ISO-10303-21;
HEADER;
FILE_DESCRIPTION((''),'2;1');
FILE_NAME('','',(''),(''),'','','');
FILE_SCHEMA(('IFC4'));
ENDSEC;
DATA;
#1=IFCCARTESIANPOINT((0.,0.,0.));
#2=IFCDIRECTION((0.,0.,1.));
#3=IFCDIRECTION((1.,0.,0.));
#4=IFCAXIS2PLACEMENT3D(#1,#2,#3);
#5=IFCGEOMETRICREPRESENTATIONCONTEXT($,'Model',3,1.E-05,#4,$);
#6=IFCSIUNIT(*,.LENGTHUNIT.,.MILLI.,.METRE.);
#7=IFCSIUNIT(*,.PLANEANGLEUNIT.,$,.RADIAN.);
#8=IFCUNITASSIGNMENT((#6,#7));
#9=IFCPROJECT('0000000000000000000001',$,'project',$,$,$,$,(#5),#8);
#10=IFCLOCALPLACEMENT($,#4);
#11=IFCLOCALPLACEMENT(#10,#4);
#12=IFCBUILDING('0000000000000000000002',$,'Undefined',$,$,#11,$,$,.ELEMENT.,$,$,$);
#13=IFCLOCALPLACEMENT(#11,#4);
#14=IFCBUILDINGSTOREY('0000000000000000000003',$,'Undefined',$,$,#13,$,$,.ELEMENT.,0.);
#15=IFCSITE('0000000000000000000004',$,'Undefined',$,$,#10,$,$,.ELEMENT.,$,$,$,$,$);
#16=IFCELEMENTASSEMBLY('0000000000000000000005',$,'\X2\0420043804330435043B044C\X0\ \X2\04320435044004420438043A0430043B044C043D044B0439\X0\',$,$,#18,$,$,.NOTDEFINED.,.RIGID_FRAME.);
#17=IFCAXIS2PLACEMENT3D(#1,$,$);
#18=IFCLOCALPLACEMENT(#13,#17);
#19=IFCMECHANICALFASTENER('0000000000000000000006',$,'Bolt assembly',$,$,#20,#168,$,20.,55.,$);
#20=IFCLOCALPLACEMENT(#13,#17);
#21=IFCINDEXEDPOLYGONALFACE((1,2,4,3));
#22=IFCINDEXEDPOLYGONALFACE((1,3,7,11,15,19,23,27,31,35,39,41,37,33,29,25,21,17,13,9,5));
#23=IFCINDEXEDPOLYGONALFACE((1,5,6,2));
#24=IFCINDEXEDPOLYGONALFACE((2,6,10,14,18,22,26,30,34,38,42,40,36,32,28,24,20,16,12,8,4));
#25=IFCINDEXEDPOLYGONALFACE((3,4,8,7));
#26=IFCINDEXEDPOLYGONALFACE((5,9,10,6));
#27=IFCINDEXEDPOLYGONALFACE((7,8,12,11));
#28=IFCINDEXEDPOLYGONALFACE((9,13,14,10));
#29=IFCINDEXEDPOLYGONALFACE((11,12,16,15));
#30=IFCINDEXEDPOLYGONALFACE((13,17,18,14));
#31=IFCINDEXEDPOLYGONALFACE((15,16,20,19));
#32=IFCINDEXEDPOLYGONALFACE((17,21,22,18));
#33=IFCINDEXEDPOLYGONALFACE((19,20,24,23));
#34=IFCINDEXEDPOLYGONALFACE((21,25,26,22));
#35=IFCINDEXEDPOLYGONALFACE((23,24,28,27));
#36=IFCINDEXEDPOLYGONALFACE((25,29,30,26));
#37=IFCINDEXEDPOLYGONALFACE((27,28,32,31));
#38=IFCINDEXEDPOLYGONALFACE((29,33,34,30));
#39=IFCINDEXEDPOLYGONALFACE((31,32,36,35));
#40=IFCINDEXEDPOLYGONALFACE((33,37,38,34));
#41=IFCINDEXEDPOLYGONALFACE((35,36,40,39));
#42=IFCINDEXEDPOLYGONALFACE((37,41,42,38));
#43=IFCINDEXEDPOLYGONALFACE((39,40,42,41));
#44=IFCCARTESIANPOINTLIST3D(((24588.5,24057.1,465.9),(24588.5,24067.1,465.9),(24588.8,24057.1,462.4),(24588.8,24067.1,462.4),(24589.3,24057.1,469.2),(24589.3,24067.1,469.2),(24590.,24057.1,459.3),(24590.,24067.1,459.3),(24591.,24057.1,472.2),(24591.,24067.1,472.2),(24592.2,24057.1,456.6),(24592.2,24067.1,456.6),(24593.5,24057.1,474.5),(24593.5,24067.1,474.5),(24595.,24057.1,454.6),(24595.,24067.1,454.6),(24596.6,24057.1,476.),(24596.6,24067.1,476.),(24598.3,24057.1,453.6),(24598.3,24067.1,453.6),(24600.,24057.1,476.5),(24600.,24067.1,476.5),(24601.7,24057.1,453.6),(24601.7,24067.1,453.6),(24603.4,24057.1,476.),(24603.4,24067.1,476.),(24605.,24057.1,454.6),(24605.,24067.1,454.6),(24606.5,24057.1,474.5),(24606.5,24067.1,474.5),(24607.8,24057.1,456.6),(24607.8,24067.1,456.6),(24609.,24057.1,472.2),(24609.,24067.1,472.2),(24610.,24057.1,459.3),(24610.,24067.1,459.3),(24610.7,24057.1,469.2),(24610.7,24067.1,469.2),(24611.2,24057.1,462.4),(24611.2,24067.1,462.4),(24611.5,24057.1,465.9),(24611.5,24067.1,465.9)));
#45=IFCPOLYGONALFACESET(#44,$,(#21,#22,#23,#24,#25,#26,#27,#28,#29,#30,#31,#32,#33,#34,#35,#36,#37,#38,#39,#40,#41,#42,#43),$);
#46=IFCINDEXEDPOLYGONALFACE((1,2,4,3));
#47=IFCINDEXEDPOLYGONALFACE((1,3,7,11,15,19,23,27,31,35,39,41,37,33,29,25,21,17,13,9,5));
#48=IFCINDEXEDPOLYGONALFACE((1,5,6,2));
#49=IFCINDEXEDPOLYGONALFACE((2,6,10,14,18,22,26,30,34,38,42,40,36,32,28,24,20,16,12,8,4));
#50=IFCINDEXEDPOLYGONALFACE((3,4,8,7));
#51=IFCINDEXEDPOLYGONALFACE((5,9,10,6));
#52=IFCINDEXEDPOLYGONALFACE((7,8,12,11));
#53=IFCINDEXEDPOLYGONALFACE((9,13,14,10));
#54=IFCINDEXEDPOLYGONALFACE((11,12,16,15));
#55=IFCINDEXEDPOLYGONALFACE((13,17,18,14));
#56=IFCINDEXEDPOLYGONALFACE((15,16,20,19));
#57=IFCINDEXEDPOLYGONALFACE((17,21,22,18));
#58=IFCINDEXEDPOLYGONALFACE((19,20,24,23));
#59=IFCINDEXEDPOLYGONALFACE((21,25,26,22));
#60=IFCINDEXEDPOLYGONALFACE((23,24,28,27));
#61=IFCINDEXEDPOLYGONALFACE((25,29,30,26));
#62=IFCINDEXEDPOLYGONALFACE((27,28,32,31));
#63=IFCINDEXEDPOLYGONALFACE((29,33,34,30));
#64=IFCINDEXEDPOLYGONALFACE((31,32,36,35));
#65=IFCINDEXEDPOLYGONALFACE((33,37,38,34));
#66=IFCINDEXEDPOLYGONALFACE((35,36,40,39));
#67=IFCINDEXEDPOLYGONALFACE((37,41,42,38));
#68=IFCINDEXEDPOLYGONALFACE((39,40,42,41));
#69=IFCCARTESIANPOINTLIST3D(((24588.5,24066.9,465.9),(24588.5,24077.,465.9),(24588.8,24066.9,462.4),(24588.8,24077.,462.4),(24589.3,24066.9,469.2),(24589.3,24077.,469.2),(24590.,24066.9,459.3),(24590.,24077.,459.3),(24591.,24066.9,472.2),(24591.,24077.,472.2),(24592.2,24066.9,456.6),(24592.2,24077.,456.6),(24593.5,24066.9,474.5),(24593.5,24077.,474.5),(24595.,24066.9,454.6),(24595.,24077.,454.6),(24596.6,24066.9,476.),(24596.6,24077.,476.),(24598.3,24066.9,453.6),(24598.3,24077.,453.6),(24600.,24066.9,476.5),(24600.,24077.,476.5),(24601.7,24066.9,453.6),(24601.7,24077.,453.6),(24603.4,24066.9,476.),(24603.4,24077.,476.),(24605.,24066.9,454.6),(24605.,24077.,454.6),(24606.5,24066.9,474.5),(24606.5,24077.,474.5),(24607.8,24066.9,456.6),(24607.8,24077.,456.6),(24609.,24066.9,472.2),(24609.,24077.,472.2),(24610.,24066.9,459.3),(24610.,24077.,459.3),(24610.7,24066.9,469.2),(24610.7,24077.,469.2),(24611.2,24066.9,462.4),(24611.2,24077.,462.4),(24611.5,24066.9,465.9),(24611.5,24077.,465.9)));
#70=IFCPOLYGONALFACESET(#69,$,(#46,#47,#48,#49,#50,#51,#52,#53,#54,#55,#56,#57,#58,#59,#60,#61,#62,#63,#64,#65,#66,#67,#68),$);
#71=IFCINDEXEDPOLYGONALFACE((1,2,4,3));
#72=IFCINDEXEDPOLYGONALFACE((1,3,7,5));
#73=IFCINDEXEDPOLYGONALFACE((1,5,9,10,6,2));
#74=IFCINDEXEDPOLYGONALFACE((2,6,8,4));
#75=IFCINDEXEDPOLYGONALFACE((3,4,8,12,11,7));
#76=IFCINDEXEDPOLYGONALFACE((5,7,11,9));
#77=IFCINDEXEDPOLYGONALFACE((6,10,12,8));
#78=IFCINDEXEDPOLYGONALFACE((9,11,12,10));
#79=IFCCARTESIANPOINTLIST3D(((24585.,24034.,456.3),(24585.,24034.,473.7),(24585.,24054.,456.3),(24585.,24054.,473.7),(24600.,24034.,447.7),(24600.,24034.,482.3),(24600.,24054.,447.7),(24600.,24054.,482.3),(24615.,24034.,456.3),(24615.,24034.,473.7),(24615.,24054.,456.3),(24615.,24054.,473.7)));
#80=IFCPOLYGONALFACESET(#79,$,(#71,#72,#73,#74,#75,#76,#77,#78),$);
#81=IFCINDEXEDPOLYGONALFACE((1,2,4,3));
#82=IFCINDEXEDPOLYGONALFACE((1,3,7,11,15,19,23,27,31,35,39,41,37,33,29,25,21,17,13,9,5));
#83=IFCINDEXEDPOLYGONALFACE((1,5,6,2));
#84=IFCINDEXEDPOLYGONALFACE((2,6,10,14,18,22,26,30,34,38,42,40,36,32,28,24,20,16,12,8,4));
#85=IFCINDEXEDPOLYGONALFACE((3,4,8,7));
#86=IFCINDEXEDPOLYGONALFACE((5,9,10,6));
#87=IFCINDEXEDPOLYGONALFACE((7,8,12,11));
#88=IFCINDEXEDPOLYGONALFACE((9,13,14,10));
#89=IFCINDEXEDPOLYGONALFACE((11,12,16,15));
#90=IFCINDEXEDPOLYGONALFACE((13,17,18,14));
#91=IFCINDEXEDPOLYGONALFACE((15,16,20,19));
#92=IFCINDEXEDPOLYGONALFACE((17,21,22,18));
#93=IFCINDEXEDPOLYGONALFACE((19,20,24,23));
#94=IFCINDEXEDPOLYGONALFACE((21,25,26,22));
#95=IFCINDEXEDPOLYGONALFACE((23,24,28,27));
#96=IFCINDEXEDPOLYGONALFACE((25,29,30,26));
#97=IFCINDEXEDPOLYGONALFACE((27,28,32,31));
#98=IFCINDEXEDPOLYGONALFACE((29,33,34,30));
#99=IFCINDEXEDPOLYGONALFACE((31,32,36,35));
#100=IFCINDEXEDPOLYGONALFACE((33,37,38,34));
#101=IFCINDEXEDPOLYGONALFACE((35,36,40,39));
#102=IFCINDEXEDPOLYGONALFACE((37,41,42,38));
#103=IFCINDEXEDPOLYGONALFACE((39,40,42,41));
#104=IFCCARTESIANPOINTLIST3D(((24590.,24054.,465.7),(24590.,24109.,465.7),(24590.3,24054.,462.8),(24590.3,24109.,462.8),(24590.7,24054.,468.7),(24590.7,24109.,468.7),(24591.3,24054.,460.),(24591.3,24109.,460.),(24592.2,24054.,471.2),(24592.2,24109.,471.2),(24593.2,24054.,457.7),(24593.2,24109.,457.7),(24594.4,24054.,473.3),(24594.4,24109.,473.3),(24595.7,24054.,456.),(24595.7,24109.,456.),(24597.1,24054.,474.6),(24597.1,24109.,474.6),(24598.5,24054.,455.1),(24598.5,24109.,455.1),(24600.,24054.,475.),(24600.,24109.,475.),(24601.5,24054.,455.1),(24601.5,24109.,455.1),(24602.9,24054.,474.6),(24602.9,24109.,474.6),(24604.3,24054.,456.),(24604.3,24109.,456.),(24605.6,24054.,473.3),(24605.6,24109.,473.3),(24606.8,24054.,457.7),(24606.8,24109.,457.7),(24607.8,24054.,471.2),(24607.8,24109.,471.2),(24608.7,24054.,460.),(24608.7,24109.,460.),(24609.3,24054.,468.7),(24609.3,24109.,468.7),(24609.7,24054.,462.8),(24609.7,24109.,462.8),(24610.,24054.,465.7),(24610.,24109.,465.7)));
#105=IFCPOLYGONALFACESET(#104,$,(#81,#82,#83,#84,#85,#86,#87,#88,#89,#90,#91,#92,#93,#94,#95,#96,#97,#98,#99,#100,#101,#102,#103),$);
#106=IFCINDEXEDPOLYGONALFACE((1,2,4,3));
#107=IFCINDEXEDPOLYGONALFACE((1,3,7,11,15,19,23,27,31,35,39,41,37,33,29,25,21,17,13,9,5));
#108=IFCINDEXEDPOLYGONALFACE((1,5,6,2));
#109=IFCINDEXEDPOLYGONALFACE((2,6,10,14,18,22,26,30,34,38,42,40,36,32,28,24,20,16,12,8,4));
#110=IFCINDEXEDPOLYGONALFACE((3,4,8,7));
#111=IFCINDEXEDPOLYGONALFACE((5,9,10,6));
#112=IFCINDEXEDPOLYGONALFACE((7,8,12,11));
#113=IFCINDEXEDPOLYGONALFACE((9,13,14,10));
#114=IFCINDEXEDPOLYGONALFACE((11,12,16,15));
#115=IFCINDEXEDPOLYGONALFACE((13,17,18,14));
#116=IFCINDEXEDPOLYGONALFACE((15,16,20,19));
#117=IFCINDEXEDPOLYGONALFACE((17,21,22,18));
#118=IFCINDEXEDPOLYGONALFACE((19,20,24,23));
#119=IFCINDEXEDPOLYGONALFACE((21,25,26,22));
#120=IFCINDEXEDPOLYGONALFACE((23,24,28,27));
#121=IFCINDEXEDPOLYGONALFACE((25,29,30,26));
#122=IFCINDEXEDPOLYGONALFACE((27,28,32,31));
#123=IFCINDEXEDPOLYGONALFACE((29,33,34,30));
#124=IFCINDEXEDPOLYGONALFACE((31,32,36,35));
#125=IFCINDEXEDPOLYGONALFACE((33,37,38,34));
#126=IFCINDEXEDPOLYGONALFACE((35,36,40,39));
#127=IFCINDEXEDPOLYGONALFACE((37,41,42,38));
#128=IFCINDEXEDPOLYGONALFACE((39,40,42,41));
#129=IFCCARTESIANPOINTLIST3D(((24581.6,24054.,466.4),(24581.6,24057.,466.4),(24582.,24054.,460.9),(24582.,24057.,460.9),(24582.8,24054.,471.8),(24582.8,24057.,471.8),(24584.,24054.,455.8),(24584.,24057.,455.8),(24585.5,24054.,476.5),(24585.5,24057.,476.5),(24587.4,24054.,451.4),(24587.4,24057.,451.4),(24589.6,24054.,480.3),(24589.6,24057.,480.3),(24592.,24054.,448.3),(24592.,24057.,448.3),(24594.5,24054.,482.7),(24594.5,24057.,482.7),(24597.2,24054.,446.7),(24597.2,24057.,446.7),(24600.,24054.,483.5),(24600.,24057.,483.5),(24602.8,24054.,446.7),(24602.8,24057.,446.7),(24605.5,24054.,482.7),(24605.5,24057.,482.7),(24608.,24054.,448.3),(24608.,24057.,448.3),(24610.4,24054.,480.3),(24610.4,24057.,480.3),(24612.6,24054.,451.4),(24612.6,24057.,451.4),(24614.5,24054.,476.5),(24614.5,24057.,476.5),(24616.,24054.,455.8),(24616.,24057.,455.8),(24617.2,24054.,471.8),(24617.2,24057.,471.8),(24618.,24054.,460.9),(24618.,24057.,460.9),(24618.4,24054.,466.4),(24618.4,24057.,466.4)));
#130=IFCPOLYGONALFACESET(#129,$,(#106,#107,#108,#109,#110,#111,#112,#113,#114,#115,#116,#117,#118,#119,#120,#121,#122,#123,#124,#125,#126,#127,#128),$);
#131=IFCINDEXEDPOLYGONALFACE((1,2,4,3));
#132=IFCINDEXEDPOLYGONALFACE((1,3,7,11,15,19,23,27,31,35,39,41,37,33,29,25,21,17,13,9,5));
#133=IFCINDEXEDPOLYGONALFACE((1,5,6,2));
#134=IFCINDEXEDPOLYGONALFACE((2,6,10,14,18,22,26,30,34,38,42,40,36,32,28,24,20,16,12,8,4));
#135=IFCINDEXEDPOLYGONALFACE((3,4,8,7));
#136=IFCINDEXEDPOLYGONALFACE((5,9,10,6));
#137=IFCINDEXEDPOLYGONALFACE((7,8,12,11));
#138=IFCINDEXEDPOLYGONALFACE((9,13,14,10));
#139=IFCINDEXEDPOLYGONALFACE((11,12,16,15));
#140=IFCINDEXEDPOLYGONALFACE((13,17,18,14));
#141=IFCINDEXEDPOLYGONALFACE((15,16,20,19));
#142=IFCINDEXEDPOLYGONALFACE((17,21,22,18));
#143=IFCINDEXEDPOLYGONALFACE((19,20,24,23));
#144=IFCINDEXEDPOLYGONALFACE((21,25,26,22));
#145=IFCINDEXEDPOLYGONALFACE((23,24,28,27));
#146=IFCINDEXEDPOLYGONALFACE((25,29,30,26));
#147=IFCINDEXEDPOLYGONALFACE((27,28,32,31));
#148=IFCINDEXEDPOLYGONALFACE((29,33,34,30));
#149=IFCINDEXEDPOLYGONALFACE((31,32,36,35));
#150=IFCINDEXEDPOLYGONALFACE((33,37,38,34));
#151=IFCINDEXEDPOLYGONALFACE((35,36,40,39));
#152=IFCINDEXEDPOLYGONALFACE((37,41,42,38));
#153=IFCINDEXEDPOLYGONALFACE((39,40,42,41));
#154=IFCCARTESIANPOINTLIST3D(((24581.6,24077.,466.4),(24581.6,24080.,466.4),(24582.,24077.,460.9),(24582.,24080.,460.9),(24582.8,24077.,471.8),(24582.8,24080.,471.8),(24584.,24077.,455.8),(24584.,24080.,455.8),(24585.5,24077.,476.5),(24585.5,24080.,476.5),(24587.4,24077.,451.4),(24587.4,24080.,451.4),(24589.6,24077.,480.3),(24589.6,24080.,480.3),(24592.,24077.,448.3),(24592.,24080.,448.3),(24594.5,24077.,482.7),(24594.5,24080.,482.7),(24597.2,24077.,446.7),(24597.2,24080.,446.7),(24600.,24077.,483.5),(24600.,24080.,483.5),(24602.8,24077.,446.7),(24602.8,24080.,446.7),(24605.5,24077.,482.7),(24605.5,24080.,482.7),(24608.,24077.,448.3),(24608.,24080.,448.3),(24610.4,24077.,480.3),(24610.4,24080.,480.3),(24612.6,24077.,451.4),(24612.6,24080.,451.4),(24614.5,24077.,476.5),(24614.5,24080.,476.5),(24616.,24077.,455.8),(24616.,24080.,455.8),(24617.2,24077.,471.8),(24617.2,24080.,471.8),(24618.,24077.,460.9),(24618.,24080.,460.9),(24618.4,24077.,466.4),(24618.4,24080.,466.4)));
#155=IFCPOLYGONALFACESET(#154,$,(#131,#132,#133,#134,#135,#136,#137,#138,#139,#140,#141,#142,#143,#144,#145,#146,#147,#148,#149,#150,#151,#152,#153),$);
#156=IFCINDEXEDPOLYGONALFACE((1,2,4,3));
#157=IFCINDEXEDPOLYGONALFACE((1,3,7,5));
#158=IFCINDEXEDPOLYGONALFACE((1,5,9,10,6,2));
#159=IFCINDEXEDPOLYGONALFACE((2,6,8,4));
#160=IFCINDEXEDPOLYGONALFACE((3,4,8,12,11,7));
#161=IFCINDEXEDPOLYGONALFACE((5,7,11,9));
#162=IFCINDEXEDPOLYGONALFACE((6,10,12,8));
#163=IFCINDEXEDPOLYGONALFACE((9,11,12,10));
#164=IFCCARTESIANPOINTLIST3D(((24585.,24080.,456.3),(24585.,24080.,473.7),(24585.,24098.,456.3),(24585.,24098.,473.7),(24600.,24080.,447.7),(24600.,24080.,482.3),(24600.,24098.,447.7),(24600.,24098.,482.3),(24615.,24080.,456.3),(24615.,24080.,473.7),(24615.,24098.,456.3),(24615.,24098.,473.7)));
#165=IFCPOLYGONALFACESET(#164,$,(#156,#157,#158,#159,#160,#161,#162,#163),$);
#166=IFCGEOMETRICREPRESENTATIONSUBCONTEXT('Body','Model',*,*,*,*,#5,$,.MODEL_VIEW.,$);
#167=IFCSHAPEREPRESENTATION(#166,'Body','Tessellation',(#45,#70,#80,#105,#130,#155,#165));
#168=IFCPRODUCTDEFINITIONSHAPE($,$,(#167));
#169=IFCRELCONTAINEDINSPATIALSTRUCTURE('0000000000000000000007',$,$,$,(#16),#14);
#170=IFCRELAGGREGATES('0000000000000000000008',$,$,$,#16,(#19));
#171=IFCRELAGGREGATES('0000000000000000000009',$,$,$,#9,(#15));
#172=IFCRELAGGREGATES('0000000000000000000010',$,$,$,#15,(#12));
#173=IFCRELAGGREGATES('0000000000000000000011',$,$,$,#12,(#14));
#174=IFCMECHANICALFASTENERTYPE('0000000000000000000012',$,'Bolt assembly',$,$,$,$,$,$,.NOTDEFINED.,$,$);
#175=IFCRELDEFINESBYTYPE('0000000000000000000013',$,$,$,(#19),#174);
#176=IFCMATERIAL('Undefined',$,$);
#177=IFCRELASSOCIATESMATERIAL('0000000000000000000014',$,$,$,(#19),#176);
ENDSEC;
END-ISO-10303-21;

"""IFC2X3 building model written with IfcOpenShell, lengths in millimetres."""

from ifc_helpers import new_model, si_unit, frame, origin_with_axes, origin_2d_with_axis, place, context, subcontext, project, spatial, polyline, circle, outline, extrude, source, transform, mapped, material, type_object, element, aggregate, save


model = new_model("IFC2X3")

# Units and contexts
model_context = context("Model", 3, precision=1e-05, world=origin_with_axes())
body_context = subcontext(model_context, "Body", "Model", "MODEL_VIEW")
ifc_project = project(units=[si_unit("LENGTHUNIT", "METRE", prefix="MILLI"), si_unit("PLANEANGLEUNIT", "RADIAN")], contexts=[model_context])

# Site, building, storey
site_placement = place(None, origin_with_axes())
site = spatial("IfcSite", under=ifc_project, at=site_placement, Name="Undefined", CompositionType="ELEMENT")
building_placement = place(site_placement, origin_with_axes())
building = spatial("IfcBuilding", under=site, at=building_placement, Name="Undefined", CompositionType="ELEMENT")
storey_placement = place(building_placement, origin_with_axes())
storey = spatial("IfcBuildingStorey", under=building, at=storey_placement, Name="Undefined", CompositionType="ELEMENT", Elevation=0.0)

# Element assembly
assembly_1_placement = place(storey_placement, origin_with_axes())
assembly_1 = element("IfcElementAssembly", 1, at=assembly_1_placement, inside=storey, Name="Ригель вертикальный", AssemblyPlace="NOTDEFINED", PredefinedType="RIGID_FRAME")

# Mechanical fastener
ifc_material_1 = material(Name="Undefined")
mechanical_fastener_type = type_object("IfcMechanicalFastenerType", Name="Bolt assembly")
shared_shape = source(origin_with_axes(), body_context, "Body", "SweptSolid", [
    extrude(circle(Radius=11.5, at=origin_2d_with_axis()), frame((0.0, 0.1, 0.0), z_axis=(0.0, 1.0, 0.0), x_axis=(1.0, 0.0, 0.0)), (0.0, 0.0, 1.0), 10.0),
    extrude(circle(Radius=11.5, at=origin_2d_with_axis()), frame((0.0, 9.9, 0.0), z_axis=(0.0, 1.0, 0.0), x_axis=(1.0, 0.0, 0.0)), (0.0, 0.0, 1.0), 10.1),
    extrude(outline(polyline([(17.3, 0.0), (8.7, 15.0), (-8.7, 15.0), (-17.3, 0.0), (-8.7, -15.0), (8.7, -15.0), (17.3, 0.0)])), frame((0.0, -23.0, 0.0), z_axis=(0.0, 1.0, 0.0), x_axis=(1.0, 0.0, 0.0)), (0.0, 0.0, 1.0), 20.0),
    extrude(circle(Radius=10.0, at=origin_2d_with_axis()), frame((0.0, -3.0, 0.0), z_axis=(0.0, 1.0, 0.0), x_axis=(1.0, 0.0, 0.0)), (0.0, 0.0, 1.0), 55.0),
    extrude(circle(Radius=18.5, at=origin_2d_with_axis()), frame((0.0, -3.0, 0.0), z_axis=(0.0, 1.0, 0.0), x_axis=(1.0, 0.0, 0.0)), (0.0, 0.0, 1.0), 3.0),
    extrude(circle(Radius=18.5, at=origin_2d_with_axis()), frame((0.0, 20.0, 0.0), z_axis=(0.0, 1.0, 0.0), x_axis=(1.0, 0.0, 0.0)), (0.0, 0.0, 1.0), 3.0),
    extrude(outline(polyline([(17.3, 0.0), (8.7, 15.0), (-8.7, 15.0), (-17.3, 0.0), (-8.7, -15.0), (8.7, -15.0), (17.3, 0.0)])), frame((0.0, 23.0, 0.0), z_axis=(0.0, 1.0, 0.0), x_axis=(1.0, 0.0, 0.0)), (0.0, 0.0, 1.0), 18.0),
])
mechanical_fastener_1_placement = place(assembly_1_placement, frame((24600.0, 24057.0, 465.0), z_axis=(-1.0, 0.0, 0.0), x_axis=(0.0, 0.0, 1.0)))
mechanical_fastener_1 = element("IfcMechanicalFastener", 2, at=mechanical_fastener_1_placement, type_object=mechanical_fastener_type, material=ifc_material_1, Name="Bolt assembly", NominalDiameter=20.0, NominalLength=55.0, context=body_context, shape_type="MappedRepresentation", body=[
    mapped(shared_shape, transform((0.0, 0.0, 0.0))),
])
aggregate(assembly_1, [mechanical_fastener_1])

save(model, "model.ifc")
